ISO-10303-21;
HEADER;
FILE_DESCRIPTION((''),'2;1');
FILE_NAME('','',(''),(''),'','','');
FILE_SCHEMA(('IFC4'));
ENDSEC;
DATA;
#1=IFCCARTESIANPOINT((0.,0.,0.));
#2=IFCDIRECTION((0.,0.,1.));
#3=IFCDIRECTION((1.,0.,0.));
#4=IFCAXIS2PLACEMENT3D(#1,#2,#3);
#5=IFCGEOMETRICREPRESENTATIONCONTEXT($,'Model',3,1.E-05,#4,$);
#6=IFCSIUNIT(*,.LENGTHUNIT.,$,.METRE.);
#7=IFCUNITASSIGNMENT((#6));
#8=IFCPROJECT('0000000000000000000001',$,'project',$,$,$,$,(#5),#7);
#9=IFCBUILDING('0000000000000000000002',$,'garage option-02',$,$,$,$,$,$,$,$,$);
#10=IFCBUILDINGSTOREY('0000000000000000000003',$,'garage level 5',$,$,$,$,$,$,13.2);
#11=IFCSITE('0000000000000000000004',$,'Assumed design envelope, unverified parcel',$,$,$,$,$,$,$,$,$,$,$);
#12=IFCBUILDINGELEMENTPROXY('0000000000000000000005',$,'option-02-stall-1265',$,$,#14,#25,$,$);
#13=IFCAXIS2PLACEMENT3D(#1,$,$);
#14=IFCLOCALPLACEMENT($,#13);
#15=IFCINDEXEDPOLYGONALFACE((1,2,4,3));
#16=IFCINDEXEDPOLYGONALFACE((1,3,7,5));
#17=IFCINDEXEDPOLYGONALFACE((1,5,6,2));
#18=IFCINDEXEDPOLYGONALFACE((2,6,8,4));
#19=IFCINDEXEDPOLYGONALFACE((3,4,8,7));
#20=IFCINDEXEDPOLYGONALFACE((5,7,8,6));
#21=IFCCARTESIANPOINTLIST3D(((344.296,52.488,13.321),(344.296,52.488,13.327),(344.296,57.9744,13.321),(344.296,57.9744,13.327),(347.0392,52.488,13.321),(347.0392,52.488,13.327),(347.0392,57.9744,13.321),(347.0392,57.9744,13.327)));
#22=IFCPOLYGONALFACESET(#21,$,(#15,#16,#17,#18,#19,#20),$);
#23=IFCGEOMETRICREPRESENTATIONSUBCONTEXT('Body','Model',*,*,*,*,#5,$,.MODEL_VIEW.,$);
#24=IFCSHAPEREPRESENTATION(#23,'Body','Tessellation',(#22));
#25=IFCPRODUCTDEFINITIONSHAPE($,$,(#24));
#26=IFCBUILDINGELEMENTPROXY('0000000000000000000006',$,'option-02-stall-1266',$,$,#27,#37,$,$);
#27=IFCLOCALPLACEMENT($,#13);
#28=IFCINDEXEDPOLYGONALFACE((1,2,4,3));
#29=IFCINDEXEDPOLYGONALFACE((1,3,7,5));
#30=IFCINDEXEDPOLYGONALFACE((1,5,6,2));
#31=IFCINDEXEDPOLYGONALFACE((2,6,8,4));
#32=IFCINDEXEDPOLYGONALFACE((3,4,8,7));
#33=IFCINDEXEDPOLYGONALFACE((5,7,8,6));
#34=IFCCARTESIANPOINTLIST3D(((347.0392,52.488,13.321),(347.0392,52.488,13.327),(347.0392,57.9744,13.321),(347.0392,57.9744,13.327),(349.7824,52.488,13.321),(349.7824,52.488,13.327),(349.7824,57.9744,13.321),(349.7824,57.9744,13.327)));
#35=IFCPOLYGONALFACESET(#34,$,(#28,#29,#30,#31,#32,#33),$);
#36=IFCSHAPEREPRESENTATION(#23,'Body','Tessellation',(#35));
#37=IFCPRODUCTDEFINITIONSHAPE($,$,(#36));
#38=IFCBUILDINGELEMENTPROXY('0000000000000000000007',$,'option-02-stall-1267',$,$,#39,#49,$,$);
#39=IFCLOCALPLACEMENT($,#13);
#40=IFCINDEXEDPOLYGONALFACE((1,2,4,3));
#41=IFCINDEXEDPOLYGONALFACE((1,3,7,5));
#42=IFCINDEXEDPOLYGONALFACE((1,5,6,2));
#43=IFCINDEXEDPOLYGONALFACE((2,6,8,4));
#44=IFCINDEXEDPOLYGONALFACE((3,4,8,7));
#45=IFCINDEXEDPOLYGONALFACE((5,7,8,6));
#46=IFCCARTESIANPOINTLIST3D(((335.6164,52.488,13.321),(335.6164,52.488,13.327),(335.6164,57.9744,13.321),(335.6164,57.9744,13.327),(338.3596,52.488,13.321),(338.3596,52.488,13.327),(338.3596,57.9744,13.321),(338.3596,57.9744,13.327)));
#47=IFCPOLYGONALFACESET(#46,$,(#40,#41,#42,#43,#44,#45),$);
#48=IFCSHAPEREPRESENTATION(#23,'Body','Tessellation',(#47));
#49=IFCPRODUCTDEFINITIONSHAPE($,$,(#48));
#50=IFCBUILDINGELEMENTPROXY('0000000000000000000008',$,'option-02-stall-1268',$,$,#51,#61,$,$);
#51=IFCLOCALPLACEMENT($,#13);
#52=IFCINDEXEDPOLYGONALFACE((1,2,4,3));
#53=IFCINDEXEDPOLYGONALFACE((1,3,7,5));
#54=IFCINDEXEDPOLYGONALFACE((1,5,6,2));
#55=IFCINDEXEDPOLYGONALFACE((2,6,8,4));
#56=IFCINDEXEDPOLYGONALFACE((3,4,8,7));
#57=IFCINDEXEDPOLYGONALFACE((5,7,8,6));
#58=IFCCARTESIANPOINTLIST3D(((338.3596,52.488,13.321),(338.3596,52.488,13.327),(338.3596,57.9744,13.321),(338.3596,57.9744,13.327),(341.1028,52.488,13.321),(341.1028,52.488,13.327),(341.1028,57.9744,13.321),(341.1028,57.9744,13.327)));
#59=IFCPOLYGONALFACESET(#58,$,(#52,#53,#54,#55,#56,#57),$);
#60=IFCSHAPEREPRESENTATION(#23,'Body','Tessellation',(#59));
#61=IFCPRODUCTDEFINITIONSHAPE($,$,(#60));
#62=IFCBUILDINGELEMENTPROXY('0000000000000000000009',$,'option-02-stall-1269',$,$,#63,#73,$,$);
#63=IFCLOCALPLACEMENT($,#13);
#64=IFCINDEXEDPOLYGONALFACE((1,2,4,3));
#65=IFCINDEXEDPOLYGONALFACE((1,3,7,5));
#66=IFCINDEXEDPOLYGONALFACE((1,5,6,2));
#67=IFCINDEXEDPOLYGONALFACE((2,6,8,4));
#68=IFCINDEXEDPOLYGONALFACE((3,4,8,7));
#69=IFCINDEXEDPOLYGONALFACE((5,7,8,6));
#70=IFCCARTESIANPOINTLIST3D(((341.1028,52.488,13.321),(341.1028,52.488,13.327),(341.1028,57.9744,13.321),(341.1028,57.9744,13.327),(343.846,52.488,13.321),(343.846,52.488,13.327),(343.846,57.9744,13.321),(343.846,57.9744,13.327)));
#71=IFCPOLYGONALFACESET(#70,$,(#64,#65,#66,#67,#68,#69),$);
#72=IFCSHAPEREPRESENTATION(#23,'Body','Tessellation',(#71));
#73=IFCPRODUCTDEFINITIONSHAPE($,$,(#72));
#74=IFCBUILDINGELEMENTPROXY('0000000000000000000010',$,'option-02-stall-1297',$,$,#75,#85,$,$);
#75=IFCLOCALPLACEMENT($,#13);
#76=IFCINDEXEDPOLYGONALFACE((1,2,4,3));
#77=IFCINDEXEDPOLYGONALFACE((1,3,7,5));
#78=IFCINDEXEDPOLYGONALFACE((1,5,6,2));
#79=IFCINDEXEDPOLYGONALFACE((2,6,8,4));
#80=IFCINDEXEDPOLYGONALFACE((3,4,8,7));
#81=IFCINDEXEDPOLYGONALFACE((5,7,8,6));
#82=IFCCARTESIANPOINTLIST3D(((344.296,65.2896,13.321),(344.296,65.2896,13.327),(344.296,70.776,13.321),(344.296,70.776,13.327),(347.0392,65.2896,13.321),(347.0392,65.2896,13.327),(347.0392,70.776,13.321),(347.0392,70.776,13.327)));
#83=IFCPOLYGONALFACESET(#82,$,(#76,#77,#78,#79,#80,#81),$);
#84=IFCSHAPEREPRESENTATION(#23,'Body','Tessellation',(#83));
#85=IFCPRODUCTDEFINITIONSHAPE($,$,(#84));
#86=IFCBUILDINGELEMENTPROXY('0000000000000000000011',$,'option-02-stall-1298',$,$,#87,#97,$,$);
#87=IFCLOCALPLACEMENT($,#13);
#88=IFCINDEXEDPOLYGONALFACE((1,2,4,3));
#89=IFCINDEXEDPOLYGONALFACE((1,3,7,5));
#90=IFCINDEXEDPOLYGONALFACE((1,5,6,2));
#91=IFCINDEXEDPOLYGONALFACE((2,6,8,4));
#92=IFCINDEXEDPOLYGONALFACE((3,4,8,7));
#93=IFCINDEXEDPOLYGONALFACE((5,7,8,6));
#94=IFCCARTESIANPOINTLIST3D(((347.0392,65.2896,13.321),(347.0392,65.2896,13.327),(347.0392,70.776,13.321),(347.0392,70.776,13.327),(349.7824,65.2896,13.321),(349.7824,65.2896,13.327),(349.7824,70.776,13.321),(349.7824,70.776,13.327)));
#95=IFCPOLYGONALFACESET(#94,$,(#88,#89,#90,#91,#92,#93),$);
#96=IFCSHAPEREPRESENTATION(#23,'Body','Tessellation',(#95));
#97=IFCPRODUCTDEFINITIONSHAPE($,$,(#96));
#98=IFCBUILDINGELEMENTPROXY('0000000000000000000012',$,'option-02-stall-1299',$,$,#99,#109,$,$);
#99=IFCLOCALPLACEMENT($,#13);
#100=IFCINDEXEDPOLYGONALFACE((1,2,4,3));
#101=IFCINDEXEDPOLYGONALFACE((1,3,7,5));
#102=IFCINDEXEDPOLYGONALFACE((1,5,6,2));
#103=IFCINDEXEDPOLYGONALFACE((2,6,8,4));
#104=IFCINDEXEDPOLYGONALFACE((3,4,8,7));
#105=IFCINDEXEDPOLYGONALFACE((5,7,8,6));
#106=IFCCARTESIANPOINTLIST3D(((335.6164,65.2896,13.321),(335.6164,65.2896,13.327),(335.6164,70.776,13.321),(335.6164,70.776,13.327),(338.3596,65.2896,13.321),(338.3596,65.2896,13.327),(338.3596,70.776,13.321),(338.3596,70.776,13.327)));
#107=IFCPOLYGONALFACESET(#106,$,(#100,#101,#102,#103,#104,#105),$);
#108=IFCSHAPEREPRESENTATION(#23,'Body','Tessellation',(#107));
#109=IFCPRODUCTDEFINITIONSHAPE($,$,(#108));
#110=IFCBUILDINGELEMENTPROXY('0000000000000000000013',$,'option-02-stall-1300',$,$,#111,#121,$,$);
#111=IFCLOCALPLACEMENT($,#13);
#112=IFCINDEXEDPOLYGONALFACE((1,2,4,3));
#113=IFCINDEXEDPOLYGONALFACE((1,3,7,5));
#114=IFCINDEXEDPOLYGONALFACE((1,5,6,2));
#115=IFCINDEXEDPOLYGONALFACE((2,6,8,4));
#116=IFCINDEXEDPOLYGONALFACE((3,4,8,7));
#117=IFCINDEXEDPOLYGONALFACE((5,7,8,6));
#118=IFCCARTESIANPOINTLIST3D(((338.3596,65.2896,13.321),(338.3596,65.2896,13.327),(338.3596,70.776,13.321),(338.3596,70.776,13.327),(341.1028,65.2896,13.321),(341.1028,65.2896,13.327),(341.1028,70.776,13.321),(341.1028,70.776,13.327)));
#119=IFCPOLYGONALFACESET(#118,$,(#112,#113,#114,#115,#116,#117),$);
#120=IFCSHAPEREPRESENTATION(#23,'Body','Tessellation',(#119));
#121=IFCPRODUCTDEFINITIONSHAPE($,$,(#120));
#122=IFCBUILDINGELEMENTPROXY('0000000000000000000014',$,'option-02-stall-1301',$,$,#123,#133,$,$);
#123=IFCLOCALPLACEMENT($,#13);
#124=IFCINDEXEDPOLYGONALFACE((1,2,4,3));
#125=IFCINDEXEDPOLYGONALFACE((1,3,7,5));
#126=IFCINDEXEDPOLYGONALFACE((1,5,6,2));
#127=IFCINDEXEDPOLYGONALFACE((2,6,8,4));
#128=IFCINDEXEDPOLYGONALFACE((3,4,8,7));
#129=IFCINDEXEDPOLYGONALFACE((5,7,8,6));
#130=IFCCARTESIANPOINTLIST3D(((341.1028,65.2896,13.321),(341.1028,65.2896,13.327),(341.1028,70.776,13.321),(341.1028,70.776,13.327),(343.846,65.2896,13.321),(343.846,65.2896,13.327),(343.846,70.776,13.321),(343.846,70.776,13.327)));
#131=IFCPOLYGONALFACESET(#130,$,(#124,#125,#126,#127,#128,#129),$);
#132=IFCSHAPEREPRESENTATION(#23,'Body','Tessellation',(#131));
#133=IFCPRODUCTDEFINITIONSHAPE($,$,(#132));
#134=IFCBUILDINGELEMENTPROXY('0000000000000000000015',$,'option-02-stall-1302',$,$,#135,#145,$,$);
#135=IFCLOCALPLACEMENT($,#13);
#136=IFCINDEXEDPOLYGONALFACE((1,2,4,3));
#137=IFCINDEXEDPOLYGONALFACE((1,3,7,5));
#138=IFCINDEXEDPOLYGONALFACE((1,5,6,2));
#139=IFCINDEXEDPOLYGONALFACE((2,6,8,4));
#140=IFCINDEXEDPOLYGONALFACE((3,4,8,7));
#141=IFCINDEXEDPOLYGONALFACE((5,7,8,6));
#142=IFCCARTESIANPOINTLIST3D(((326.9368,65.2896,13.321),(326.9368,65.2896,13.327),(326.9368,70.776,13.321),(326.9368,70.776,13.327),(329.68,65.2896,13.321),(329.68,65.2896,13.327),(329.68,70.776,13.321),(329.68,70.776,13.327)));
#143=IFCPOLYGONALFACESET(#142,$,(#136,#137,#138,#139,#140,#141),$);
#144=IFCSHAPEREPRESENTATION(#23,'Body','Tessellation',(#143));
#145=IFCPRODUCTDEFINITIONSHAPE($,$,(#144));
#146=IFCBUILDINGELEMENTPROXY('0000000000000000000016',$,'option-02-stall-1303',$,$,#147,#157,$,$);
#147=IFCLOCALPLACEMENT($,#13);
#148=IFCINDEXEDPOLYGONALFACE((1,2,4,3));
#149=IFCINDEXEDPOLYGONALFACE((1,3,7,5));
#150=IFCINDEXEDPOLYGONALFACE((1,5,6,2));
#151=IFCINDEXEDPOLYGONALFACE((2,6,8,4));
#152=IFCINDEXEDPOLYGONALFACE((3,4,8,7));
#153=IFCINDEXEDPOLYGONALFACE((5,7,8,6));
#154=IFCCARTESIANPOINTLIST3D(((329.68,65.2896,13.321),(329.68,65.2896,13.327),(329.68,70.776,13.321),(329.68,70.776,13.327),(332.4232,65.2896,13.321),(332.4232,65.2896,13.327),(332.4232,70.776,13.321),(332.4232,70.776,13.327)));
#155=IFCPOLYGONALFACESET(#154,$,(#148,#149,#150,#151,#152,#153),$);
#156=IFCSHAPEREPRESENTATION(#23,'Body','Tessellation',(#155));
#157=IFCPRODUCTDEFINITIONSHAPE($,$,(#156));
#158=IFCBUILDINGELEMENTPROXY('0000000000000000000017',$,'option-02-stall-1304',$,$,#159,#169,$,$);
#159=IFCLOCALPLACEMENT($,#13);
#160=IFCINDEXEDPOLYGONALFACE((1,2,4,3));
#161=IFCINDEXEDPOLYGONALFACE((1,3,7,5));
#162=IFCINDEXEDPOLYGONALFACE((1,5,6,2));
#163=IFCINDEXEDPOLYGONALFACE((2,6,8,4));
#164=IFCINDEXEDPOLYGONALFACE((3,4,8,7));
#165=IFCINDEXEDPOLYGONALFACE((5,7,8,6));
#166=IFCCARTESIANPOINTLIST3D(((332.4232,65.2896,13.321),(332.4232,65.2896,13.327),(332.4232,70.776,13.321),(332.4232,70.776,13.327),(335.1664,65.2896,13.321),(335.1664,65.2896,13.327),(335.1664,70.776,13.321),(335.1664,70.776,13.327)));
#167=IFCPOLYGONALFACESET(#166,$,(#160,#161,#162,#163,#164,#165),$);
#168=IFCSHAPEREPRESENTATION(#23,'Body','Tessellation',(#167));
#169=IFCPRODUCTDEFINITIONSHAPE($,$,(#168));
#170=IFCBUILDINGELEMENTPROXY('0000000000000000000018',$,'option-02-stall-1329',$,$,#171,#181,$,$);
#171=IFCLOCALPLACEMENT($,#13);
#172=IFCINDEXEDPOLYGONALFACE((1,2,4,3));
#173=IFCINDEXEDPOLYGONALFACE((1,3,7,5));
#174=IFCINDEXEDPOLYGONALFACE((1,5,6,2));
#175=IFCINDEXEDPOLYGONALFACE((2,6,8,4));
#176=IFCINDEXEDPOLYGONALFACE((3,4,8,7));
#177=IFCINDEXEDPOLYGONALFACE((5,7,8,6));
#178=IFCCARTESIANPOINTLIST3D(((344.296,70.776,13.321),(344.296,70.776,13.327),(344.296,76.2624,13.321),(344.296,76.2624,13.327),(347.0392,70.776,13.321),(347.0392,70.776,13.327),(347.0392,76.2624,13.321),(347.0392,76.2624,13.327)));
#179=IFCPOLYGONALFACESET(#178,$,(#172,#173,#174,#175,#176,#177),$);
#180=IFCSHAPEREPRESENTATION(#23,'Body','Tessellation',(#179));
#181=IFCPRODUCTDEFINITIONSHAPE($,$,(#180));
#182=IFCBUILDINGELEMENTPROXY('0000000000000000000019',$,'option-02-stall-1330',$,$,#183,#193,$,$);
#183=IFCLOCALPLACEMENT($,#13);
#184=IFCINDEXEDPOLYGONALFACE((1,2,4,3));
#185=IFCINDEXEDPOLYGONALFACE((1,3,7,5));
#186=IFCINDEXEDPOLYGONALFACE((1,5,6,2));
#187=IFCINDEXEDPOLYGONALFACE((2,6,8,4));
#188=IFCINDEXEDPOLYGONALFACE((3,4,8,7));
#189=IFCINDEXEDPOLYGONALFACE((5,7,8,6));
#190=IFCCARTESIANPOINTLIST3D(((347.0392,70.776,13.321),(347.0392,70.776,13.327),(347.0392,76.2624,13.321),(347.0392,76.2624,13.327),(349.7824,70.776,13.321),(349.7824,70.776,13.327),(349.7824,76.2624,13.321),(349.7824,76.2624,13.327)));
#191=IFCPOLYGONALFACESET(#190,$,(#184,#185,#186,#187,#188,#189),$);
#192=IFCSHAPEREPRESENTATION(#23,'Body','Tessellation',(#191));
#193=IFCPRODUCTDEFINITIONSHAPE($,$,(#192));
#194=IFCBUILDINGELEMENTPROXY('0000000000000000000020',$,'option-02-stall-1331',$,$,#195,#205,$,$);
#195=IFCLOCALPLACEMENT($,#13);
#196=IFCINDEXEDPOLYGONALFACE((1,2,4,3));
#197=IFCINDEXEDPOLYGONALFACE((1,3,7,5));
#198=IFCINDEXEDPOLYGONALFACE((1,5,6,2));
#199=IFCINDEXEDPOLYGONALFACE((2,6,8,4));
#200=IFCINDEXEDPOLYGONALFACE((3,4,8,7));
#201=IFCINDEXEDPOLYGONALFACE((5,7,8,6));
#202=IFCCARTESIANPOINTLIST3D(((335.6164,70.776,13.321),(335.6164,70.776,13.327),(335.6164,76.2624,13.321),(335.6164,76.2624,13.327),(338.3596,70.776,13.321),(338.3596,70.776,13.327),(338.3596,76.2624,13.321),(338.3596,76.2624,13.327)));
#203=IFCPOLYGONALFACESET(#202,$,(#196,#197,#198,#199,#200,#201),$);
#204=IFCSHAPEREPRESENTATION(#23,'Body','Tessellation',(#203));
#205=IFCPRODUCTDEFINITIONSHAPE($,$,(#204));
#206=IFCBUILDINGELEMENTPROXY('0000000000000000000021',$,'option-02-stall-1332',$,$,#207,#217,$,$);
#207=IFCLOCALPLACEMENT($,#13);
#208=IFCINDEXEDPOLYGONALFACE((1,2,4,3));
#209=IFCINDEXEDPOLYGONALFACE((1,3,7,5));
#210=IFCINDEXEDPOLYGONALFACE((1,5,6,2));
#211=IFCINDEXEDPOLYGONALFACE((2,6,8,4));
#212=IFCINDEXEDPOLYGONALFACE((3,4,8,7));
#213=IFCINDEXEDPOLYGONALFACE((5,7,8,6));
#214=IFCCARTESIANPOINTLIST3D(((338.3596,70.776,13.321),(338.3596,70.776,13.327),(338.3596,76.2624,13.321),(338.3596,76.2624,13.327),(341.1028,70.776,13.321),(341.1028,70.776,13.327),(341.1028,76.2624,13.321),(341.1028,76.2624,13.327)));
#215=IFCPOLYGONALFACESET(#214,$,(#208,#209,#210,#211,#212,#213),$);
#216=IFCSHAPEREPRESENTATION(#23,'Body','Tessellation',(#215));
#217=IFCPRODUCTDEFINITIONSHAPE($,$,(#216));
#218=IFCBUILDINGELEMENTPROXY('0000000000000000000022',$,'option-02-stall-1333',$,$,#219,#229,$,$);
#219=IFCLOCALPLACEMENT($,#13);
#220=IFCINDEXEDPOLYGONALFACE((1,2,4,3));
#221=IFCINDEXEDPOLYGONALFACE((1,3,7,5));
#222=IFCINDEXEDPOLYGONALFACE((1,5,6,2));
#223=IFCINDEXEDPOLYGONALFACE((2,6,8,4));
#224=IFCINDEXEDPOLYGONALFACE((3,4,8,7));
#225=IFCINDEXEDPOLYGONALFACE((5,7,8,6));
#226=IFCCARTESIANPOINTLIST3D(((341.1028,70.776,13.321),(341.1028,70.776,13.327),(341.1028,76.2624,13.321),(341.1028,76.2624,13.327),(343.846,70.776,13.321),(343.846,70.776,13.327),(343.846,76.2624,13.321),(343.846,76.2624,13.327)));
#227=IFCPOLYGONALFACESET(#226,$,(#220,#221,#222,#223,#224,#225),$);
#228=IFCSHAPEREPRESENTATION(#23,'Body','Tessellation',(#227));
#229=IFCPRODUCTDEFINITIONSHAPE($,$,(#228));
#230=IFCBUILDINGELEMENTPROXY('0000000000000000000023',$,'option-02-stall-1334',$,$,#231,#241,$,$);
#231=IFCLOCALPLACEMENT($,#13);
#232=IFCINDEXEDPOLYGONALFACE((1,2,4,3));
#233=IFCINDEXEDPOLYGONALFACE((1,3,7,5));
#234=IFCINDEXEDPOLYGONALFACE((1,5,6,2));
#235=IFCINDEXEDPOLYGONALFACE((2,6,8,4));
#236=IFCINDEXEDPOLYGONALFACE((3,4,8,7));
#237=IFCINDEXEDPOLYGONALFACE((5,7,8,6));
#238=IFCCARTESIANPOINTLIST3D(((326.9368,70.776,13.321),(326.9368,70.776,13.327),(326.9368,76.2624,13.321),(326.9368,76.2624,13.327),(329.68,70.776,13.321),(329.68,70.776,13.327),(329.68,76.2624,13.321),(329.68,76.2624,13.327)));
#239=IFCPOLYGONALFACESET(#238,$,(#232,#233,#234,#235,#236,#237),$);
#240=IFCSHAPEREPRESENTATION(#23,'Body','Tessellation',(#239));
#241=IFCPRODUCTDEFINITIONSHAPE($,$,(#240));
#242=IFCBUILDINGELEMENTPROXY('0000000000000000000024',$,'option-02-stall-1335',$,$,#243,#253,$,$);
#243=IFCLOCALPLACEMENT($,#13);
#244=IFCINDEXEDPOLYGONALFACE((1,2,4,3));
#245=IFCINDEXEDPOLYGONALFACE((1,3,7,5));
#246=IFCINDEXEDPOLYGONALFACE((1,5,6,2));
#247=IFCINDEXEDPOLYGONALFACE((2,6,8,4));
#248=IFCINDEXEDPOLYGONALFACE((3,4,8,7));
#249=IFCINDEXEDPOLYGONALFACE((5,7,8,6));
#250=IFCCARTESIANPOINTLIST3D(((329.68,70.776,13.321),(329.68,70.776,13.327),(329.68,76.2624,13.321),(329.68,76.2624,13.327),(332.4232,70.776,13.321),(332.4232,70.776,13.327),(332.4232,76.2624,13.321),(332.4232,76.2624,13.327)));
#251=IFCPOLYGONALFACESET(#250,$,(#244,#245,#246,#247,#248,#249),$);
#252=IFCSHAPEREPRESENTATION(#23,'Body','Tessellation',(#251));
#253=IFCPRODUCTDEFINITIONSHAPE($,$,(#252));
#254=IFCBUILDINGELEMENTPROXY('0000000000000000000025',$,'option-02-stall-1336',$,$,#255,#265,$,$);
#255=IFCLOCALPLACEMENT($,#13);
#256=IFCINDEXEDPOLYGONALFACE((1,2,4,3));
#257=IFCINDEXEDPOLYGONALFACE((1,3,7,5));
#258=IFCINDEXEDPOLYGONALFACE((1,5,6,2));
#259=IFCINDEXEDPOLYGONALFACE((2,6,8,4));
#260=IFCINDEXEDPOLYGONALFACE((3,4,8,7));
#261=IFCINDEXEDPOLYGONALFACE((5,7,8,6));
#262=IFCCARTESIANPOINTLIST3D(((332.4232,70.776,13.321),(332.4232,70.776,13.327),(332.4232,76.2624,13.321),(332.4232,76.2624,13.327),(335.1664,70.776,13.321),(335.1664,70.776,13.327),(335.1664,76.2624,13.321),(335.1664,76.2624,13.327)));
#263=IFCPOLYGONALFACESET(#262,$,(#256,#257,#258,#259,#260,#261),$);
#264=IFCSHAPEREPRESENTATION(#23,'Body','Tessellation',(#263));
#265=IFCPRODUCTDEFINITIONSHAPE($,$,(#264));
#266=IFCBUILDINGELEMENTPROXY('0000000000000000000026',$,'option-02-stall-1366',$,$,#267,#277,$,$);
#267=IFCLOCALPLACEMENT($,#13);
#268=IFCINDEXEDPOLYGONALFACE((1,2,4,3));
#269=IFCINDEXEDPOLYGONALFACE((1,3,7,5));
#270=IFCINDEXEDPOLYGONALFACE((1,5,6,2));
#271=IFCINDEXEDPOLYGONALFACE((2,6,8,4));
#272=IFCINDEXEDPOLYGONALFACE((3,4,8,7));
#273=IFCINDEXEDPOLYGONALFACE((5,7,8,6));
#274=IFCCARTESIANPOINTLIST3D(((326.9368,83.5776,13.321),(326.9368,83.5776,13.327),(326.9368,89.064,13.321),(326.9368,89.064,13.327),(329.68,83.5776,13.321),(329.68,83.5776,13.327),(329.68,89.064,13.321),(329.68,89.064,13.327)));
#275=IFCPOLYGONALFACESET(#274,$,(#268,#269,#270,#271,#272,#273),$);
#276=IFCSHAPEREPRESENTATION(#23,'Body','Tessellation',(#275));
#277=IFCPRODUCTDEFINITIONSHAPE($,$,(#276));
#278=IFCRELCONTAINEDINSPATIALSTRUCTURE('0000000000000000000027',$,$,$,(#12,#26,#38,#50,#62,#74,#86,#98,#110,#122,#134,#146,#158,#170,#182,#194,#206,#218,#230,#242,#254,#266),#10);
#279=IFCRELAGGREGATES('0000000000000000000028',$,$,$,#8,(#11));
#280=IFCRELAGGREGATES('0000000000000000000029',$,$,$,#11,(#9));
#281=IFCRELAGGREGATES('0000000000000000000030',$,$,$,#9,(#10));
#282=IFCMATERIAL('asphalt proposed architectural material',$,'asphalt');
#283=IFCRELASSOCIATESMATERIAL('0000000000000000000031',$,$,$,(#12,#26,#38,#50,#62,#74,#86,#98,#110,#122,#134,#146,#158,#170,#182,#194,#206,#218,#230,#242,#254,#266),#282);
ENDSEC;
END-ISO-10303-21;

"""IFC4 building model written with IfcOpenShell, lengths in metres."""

from ifc_helpers import new_model, si_unit, frame, origin_with_axes, place, context, subcontext, project, spatial, rectangle, extrude, material, element, save


model = new_model("IFC4")

# Units and contexts
model_context = context("Model", 3, precision=1e-05, world=origin_with_axes())
body_context = subcontext(model_context, "Body", "Model", "MODEL_VIEW")
ifc_project = project(units=[si_unit("LENGTHUNIT", "METRE")], contexts=[model_context])

# Site, building, storey
site = spatial("IfcSite", under=ifc_project, Name="Assumed design envelope, unverified parcel")
building = spatial("IfcBuilding", under=site, Name="garage option-02")
storey = spatial("IfcBuildingStorey", under=building, Name="garage level 5", Elevation=13.2)

# Building element proxies
ifc_material = material(Name="asphalt proposed architectural material", Category="asphalt")
for number, where, z_axis, x_axis, name in (
    (1, (345.6676, 55.2312, 13.321), (0.0, 0.0, 1.0), (1.0, 0.0, 0.0), "option-02-stall-1265"),
    (2, (348.4108, 55.2312, 13.321), (0.0, 0.0, 1.0), (1.0, 0.0, 0.0), "option-02-stall-1266"),
    (3, (336.988, 55.2312, 13.321), (0.0, 0.0, 1.0), (1.0, 0.0, 0.0), "option-02-stall-1267"),
    (4, (339.7312, 55.2312, 13.321), (0.0, 0.0, 1.0), (1.0, 0.0, 0.0), "option-02-stall-1268"),
    (5, (342.4744, 55.2312, 13.321), (0.0, 0.0, 1.0), (1.0, 0.0, 0.0), "option-02-stall-1269"),
    (6, (345.6676, 68.0328, 13.321), (0.0, 0.0, 1.0), (1.0, 0.0, 0.0), "option-02-stall-1297"),
    (7, (348.4108, 68.0328, 13.321), (0.0, 0.0, 1.0), (1.0, 0.0, 0.0), "option-02-stall-1298"),
    (8, (336.988, 68.0328, 13.321), (0.0, 0.0, 1.0), (1.0, 0.0, 0.0), "option-02-stall-1299"),
    (9, (339.7312, 68.0328, 13.321), (0.0, 0.0, 1.0), (1.0, 0.0, 0.0), "option-02-stall-1300"),
    (10, (342.4744, 68.0328, 13.321), (0.0, 0.0, 1.0), (1.0, 0.0, 0.0), "option-02-stall-1301"),
    (11, (328.3084, 68.0328, 13.321), (0.0, 0.0, 1.0), (1.0, 0.0, 0.0), "option-02-stall-1302"),
    (12, (331.0516, 68.0328, 13.321), (0.0, 0.0, 1.0), (1.0, 0.0, 0.0), "option-02-stall-1303"),
    (13, (333.7948, 68.0328, 13.321), (0.0, 0.0, 1.0), (1.0, 0.0, 0.0), "option-02-stall-1304"),
    (14, (345.6676, 73.5192, 13.321), (0.0, 0.0, 1.0), (1.0, 0.0, 0.0), "option-02-stall-1329"),
    (15, (348.4108, 73.5192, 13.321), (0.0, 0.0, 1.0), (1.0, 0.0, 0.0), "option-02-stall-1330"),
    (16, (336.988, 73.5192, 13.321), (0.0, 0.0, 1.0), (1.0, 0.0, 0.0), "option-02-stall-1331"),
    (17, (339.7312, 73.5192, 13.321), (0.0, 0.0, 1.0), (1.0, 0.0, 0.0), "option-02-stall-1332"),
    (18, (342.4744, 73.5192, 13.321), (0.0, 0.0, 1.0), (1.0, 0.0, 0.0), "option-02-stall-1333"),
    (19, (328.3084, 73.5192, 13.321), (0.0, 0.0, 1.0), (1.0, 0.0, 0.0), "option-02-stall-1334"),
    (20, (331.0516, 73.5192, 13.321), (0.0, 0.0, 1.0), (1.0, 0.0, 0.0), "option-02-stall-1335"),
    (21, (333.7948, 73.5192, 13.321), (0.0, 0.0, 1.0), (1.0, 0.0, 0.0), "option-02-stall-1336"),
    (22, (328.3084, 86.3208, 13.321), (0.0, 0.0, 1.0), (1.0, 0.0, 0.0), "option-02-stall-1366"),
):
    element("IfcBuildingElementProxy", number, at=place(None, frame(where, z_axis=z_axis, x_axis=x_axis)), inside=storey, material=ifc_material, Name=name, context=body_context, shape_type="SweptSolid", body=[
        extrude(rectangle(XDim=2.7432, YDim=5.4864), origin_with_axes(), (0.0, 0.0, 1.0), 0.006),
    ])

save(model, "model.ifc")
